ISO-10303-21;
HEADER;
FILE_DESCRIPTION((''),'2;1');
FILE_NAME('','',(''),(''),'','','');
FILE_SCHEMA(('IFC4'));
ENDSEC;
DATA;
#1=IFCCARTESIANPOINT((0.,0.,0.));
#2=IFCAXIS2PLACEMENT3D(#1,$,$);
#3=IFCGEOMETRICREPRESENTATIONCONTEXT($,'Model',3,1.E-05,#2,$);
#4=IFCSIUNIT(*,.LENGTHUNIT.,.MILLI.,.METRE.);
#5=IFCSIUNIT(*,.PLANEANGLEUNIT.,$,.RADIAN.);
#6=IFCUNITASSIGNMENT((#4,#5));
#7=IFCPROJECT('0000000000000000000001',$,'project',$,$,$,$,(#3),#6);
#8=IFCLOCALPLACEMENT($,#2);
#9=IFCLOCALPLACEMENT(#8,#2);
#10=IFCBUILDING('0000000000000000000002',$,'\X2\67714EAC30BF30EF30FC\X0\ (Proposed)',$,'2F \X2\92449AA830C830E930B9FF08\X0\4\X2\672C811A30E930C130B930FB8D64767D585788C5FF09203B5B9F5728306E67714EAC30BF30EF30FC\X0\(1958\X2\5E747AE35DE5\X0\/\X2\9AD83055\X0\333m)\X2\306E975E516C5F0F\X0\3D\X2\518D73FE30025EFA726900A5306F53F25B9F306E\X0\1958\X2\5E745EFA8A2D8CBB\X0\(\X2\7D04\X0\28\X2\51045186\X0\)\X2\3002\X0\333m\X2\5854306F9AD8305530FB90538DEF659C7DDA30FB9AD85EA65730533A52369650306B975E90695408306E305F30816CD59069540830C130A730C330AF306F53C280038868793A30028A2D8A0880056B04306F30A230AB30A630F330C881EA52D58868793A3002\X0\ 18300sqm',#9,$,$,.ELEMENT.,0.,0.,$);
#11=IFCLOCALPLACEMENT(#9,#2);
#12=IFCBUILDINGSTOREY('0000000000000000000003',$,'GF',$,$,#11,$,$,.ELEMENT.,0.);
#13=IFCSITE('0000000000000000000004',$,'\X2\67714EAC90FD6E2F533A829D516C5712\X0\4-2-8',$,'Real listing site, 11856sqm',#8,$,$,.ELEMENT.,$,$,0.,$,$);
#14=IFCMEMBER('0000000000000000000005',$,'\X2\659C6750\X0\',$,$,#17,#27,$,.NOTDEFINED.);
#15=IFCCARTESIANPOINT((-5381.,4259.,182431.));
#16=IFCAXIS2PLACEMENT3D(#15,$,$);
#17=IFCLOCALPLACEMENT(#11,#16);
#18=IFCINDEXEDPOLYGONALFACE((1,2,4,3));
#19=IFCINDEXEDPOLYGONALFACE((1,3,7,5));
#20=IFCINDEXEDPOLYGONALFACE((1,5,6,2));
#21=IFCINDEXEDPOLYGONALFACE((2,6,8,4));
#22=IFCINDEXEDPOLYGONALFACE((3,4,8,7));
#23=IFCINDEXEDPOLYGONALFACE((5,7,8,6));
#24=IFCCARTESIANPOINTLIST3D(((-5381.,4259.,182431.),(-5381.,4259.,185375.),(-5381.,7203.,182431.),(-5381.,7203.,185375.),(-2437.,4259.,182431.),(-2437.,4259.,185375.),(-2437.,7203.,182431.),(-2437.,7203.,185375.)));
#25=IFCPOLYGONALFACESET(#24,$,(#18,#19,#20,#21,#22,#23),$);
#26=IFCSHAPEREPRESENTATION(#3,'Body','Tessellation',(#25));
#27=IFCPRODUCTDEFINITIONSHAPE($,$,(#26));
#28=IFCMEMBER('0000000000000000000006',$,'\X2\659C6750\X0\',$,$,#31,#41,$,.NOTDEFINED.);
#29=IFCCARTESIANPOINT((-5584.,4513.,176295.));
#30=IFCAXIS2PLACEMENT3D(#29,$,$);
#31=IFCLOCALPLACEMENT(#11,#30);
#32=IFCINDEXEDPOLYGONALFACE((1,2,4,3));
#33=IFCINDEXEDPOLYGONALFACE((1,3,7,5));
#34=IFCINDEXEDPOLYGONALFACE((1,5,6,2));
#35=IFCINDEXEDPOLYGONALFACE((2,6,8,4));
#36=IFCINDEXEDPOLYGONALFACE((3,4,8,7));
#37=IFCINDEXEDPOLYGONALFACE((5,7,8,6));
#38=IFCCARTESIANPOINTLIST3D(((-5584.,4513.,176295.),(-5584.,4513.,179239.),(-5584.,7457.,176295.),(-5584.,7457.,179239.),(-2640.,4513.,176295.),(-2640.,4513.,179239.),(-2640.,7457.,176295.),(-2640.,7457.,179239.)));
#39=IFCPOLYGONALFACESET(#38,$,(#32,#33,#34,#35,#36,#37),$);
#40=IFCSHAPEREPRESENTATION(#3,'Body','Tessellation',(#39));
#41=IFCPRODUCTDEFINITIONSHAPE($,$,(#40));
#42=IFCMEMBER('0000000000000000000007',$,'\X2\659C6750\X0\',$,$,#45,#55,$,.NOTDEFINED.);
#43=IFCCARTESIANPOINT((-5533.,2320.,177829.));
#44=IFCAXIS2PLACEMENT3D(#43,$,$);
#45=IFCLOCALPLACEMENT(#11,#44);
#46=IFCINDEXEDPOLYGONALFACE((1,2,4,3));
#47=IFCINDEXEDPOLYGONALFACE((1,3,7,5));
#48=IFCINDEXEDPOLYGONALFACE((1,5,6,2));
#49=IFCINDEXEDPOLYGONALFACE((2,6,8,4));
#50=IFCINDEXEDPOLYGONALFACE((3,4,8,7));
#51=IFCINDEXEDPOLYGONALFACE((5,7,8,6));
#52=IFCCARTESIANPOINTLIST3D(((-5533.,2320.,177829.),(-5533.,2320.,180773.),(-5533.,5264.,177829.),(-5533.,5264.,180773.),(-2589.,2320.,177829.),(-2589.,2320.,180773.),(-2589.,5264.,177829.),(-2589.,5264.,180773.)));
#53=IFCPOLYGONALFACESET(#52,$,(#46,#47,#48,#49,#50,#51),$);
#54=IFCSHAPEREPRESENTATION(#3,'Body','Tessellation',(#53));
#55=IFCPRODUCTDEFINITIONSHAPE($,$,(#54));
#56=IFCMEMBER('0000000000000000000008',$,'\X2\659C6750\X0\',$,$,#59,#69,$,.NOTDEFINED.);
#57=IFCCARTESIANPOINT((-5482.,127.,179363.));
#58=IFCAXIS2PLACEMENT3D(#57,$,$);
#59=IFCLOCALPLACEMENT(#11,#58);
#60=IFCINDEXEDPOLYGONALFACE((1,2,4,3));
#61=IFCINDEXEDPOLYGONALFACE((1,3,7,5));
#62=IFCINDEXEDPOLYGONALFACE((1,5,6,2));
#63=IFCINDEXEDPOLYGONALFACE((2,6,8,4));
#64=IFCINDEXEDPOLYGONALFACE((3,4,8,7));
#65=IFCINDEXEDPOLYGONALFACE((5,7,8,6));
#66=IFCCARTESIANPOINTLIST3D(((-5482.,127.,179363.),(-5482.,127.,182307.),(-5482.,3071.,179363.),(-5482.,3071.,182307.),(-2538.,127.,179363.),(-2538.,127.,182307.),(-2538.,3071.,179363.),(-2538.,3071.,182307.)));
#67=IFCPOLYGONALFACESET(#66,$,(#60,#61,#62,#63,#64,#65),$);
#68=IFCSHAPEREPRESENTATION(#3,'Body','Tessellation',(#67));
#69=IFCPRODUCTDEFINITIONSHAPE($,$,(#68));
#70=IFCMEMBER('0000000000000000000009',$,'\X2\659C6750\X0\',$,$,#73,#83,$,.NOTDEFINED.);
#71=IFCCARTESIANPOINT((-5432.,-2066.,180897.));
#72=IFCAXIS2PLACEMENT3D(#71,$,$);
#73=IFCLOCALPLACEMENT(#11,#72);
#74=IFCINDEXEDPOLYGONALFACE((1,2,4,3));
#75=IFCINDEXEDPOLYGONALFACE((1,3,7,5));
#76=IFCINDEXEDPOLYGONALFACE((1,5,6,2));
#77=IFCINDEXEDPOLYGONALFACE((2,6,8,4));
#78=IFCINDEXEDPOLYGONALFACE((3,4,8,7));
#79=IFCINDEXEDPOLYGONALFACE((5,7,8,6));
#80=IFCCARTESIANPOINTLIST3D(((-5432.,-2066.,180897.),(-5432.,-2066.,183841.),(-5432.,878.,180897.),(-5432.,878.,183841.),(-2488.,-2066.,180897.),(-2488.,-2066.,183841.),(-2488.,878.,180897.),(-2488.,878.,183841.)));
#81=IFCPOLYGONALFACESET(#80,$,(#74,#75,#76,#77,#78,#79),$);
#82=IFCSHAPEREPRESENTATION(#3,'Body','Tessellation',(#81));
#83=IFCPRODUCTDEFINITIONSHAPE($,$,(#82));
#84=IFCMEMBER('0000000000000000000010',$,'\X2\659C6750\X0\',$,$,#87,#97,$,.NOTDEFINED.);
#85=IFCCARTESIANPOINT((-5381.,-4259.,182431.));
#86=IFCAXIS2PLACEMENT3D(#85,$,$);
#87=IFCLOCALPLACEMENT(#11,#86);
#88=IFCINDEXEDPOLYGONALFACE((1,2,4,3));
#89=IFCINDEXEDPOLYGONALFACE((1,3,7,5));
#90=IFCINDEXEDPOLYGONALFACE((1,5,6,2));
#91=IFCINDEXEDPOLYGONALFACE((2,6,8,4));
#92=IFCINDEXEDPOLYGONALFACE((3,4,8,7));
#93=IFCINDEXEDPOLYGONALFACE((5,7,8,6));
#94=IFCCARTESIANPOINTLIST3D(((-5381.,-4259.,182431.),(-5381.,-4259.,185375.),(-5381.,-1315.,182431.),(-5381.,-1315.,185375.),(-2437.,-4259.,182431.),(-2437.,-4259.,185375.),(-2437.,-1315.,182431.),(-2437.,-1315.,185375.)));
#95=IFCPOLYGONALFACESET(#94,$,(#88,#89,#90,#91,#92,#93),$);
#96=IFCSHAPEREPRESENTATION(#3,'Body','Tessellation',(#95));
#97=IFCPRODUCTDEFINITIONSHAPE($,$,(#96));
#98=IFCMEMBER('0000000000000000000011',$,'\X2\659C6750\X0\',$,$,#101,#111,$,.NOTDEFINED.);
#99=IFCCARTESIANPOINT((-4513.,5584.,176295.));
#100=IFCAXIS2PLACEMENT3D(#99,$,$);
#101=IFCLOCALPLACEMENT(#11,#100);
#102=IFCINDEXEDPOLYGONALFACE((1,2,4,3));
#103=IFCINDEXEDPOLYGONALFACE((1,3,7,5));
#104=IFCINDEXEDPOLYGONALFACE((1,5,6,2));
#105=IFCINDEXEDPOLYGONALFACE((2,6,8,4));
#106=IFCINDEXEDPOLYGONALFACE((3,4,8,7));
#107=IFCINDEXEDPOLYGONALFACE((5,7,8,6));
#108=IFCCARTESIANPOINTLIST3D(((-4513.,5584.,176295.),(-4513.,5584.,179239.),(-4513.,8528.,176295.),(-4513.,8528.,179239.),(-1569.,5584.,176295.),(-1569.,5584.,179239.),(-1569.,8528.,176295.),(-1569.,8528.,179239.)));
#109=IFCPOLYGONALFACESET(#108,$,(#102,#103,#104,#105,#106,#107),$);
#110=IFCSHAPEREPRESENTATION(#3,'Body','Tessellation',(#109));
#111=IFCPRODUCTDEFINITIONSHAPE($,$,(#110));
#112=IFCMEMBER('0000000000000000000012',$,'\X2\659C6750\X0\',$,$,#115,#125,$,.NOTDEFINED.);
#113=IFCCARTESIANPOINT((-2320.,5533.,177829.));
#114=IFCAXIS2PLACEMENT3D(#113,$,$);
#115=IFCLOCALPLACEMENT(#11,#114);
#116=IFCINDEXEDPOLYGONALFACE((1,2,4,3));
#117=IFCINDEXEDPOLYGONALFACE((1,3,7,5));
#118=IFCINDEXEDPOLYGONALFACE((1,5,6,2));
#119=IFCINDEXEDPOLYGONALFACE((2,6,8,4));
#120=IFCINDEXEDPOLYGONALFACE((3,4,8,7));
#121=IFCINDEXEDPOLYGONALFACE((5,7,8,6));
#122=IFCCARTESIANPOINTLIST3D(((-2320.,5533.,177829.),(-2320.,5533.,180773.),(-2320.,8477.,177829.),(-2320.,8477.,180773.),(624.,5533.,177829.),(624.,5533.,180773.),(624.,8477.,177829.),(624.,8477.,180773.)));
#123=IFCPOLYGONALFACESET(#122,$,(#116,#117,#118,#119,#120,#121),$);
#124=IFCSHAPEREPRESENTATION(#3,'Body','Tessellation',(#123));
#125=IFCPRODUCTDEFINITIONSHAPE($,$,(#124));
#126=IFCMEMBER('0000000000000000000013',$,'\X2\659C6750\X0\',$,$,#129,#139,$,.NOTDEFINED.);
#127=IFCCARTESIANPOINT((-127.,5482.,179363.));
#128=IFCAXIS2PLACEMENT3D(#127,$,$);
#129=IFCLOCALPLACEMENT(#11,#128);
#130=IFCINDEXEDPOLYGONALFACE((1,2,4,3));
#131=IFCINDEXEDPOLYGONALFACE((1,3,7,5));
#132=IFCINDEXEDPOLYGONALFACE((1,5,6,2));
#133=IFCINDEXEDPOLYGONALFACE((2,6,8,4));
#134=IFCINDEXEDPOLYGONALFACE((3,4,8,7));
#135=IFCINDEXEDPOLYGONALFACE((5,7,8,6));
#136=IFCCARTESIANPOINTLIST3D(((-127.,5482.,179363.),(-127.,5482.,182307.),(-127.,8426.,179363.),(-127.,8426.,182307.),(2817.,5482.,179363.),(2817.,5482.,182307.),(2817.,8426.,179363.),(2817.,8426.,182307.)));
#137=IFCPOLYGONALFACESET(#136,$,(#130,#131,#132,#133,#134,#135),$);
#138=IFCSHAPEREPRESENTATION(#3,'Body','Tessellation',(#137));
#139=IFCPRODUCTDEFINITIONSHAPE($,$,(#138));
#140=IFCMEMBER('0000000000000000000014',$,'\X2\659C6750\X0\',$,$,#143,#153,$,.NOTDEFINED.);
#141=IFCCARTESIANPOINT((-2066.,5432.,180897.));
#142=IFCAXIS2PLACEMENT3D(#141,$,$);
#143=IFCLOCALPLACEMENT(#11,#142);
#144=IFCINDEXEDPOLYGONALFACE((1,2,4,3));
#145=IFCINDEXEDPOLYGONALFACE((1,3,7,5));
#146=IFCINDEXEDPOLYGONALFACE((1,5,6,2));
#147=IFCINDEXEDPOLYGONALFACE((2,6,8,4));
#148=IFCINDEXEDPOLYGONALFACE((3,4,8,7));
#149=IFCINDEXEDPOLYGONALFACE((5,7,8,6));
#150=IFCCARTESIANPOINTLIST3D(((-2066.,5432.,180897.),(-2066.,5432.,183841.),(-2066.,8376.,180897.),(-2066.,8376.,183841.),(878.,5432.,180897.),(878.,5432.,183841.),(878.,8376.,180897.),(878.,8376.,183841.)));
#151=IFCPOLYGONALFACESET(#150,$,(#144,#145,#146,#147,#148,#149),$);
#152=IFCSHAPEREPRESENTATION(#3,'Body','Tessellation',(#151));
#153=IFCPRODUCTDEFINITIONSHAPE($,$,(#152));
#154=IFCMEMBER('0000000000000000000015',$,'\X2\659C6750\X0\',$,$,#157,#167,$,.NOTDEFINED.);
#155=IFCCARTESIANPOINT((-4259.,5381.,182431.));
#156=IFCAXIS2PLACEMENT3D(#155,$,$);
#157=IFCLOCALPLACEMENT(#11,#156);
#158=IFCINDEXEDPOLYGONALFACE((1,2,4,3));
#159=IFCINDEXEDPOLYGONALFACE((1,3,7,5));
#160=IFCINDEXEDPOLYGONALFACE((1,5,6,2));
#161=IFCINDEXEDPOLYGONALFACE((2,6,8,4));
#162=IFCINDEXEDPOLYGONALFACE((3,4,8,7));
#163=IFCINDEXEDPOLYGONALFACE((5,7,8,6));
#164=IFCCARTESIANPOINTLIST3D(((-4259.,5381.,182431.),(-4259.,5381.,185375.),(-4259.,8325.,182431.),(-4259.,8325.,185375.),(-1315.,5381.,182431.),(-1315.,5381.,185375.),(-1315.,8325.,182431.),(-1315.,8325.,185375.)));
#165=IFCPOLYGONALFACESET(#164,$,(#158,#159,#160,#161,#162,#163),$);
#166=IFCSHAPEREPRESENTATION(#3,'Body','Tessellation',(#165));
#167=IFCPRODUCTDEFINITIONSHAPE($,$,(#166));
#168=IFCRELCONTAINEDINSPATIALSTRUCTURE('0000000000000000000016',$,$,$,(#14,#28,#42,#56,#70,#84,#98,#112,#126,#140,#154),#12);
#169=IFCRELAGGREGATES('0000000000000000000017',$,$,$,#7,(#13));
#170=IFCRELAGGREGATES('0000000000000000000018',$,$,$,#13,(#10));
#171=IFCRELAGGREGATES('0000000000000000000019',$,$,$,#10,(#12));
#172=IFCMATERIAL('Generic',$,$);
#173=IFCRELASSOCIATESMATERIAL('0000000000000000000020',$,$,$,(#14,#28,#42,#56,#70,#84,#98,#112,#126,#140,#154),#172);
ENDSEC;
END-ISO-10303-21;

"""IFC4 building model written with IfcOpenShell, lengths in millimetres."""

from ifc_helpers import new_model, si_unit, frame, frame_2d, origin, place, context, project, spatial, rectangle, extrude, material, element, save


model = new_model("IFC4")

# Units and contexts
model_context = context("Model", 3, precision=1e-05, world=origin())
ifc_project = project(units=[si_unit("LENGTHUNIT", "METRE", prefix="MILLI"), si_unit("PLANEANGLEUNIT", "RADIAN")], contexts=[model_context])

# Site, building, storey
site_placement = place(None, origin())
site = spatial("IfcSite", under=ifc_project, at=site_placement, Name="東京都港区芝公園4-2-8", ObjectType="Real listing site, 11856sqm", CompositionType="ELEMENT", RefElevation=0.0)
building_placement = place(site_placement, origin())
building = spatial("IfcBuilding", under=site, at=building_placement, Name="東京タワー (Proposed)", ObjectType="2F 鉄骨トラス（4本脚ラチス・赤白塗装）※実在の東京タワー(1958年竣工/高さ333m)の非公式3D再現。建物¥は史実の1958年建設費(約28億円)。333m塔は高さ・道路斜線・高度地区制限に非適合のため法適合チェックは参考表示。設計者欄はアカウント自動表示。 18300sqm", CompositionType="ELEMENT", ElevationOfRefHeight=0.0, ElevationOfTerrain=0.0)
storey_placement = place(building_placement, origin())
storey = spatial("IfcBuildingStorey", under=building, at=storey_placement, Name="GF", CompositionType="ELEMENT", Elevation=0.0)

# Shared definitions
ifc_material = material(Name="Generic")

# Members
member_1_placement = place(storey_placement, frame((-5381.0, 4259.0, 182431.0)))
element("IfcMember", 1, at=member_1_placement, inside=storey, material=ifc_material, Name="斜材", PredefinedType="NOTDEFINED", context=model_context, shape_type="SweptSolid", body=[
    extrude(rectangle(XDim=2944.0, YDim=2944.0, at=frame_2d((1472.0, 1472.0))), frame((-5381.0, 4259.0, 182431.0)), (0.0, 0.0, 1.0), 2944.0),
])
member_2_placement = place(storey_placement, frame((-5584.0, 4513.0, 176295.0)))
element("IfcMember", 2, at=member_2_placement, inside=storey, material=ifc_material, Name="斜材", PredefinedType="NOTDEFINED", context=model_context, shape_type="SweptSolid", body=[
    extrude(rectangle(XDim=2944.0, YDim=2944.0, at=frame_2d((1472.0, 1472.0))), frame((-5584.0, 4513.0, 176295.0)), (0.0, 0.0, 1.0), 2944.0),
])
member_3_placement = place(storey_placement, frame((-5533.0, 2320.0, 177829.0)))
element("IfcMember", 3, at=member_3_placement, inside=storey, material=ifc_material, Name="斜材", PredefinedType="NOTDEFINED", context=model_context, shape_type="SweptSolid", body=[
    extrude(rectangle(XDim=2944.0, YDim=2944.0, at=frame_2d((1472.0, 1472.0))), frame((-5533.0, 2320.0, 177829.0)), (0.0, 0.0, 1.0), 2944.0),
])
member_4_placement = place(storey_placement, frame((-5482.0, 127.0, 179363.0)))
element("IfcMember", 4, at=member_4_placement, inside=storey, material=ifc_material, Name="斜材", PredefinedType="NOTDEFINED", context=model_context, shape_type="SweptSolid", body=[
    extrude(rectangle(XDim=2944.0, YDim=2944.0, at=frame_2d((1472.0, 1472.0))), frame((-5482.0, 127.0, 179363.0)), (0.0, 0.0, 1.0), 2944.0),
])
member_5_placement = place(storey_placement, frame((-5432.0, -2066.0, 180897.0)))
element("IfcMember", 5, at=member_5_placement, inside=storey, material=ifc_material, Name="斜材", PredefinedType="NOTDEFINED", context=model_context, shape_type="SweptSolid", body=[
    extrude(rectangle(XDim=2944.0, YDim=2944.0, at=frame_2d((1472.0, 1472.0))), frame((-5432.0, -2066.0, 180897.0)), (0.0, 0.0, 1.0), 2944.0),
])
member_6_placement = place(storey_placement, frame((-5381.0, -4259.0, 182431.0)))
element("IfcMember", 6, at=member_6_placement, inside=storey, material=ifc_material, Name="斜材", PredefinedType="NOTDEFINED", context=model_context, shape_type="SweptSolid", body=[
    extrude(rectangle(XDim=2944.0, YDim=2944.0, at=frame_2d((1472.0, 1472.0))), frame((-5381.0, -4259.0, 182431.0)), (0.0, 0.0, 1.0), 2944.0),
])
member_7_placement = place(storey_placement, frame((-4513.0, 5584.0, 176295.0)))
element("IfcMember", 7, at=member_7_placement, inside=storey, material=ifc_material, Name="斜材", PredefinedType="NOTDEFINED", context=model_context, shape_type="SweptSolid", body=[
    extrude(rectangle(XDim=2944.0, YDim=2944.0, at=frame_2d((1472.0, 1472.0))), frame((-4513.0, 5584.0, 176295.0)), (0.0, 0.0, 1.0), 2944.0),
])
member_8_placement = place(storey_placement, frame((-2320.0, 5533.0, 177829.0)))
element("IfcMember", 8, at=member_8_placement, inside=storey, material=ifc_material, Name="斜材", PredefinedType="NOTDEFINED", context=model_context, shape_type="SweptSolid", body=[
    extrude(rectangle(XDim=2944.0, YDim=2944.0, at=frame_2d((1472.0, 1472.0))), frame((-2320.0, 5533.0, 177829.0)), (0.0, 0.0, 1.0), 2944.0),
])
member_9_placement = place(storey_placement, frame((-127.0, 5482.0, 179363.0)))
element("IfcMember", 9, at=member_9_placement, inside=storey, material=ifc_material, Name="斜材", PredefinedType="NOTDEFINED", context=model_context, shape_type="SweptSolid", body=[
    extrude(rectangle(XDim=2944.0, YDim=2944.0, at=frame_2d((1472.0, 1472.0))), frame((-127.0, 5482.0, 179363.0)), (0.0, 0.0, 1.0), 2944.0),
])
member_10_placement = place(storey_placement, frame((-2066.0, 5432.0, 180897.0)))
element("IfcMember", 10, at=member_10_placement, inside=storey, material=ifc_material, Name="斜材", PredefinedType="NOTDEFINED", context=model_context, shape_type="SweptSolid", body=[
    extrude(rectangle(XDim=2944.0, YDim=2944.0, at=frame_2d((1472.0, 1472.0))), frame((-2066.0, 5432.0, 180897.0)), (0.0, 0.0, 1.0), 2944.0),
])
member_11_placement = place(storey_placement, frame((-4259.0, 5381.0, 182431.0)))
element("IfcMember", 11, at=member_11_placement, inside=storey, material=ifc_material, Name="斜材", PredefinedType="NOTDEFINED", context=model_context, shape_type="SweptSolid", body=[
    extrude(rectangle(XDim=2944.0, YDim=2944.0, at=frame_2d((1472.0, 1472.0))), frame((-4259.0, 5381.0, 182431.0)), (0.0, 0.0, 1.0), 2944.0),
])

save(model, "model.ifc")
